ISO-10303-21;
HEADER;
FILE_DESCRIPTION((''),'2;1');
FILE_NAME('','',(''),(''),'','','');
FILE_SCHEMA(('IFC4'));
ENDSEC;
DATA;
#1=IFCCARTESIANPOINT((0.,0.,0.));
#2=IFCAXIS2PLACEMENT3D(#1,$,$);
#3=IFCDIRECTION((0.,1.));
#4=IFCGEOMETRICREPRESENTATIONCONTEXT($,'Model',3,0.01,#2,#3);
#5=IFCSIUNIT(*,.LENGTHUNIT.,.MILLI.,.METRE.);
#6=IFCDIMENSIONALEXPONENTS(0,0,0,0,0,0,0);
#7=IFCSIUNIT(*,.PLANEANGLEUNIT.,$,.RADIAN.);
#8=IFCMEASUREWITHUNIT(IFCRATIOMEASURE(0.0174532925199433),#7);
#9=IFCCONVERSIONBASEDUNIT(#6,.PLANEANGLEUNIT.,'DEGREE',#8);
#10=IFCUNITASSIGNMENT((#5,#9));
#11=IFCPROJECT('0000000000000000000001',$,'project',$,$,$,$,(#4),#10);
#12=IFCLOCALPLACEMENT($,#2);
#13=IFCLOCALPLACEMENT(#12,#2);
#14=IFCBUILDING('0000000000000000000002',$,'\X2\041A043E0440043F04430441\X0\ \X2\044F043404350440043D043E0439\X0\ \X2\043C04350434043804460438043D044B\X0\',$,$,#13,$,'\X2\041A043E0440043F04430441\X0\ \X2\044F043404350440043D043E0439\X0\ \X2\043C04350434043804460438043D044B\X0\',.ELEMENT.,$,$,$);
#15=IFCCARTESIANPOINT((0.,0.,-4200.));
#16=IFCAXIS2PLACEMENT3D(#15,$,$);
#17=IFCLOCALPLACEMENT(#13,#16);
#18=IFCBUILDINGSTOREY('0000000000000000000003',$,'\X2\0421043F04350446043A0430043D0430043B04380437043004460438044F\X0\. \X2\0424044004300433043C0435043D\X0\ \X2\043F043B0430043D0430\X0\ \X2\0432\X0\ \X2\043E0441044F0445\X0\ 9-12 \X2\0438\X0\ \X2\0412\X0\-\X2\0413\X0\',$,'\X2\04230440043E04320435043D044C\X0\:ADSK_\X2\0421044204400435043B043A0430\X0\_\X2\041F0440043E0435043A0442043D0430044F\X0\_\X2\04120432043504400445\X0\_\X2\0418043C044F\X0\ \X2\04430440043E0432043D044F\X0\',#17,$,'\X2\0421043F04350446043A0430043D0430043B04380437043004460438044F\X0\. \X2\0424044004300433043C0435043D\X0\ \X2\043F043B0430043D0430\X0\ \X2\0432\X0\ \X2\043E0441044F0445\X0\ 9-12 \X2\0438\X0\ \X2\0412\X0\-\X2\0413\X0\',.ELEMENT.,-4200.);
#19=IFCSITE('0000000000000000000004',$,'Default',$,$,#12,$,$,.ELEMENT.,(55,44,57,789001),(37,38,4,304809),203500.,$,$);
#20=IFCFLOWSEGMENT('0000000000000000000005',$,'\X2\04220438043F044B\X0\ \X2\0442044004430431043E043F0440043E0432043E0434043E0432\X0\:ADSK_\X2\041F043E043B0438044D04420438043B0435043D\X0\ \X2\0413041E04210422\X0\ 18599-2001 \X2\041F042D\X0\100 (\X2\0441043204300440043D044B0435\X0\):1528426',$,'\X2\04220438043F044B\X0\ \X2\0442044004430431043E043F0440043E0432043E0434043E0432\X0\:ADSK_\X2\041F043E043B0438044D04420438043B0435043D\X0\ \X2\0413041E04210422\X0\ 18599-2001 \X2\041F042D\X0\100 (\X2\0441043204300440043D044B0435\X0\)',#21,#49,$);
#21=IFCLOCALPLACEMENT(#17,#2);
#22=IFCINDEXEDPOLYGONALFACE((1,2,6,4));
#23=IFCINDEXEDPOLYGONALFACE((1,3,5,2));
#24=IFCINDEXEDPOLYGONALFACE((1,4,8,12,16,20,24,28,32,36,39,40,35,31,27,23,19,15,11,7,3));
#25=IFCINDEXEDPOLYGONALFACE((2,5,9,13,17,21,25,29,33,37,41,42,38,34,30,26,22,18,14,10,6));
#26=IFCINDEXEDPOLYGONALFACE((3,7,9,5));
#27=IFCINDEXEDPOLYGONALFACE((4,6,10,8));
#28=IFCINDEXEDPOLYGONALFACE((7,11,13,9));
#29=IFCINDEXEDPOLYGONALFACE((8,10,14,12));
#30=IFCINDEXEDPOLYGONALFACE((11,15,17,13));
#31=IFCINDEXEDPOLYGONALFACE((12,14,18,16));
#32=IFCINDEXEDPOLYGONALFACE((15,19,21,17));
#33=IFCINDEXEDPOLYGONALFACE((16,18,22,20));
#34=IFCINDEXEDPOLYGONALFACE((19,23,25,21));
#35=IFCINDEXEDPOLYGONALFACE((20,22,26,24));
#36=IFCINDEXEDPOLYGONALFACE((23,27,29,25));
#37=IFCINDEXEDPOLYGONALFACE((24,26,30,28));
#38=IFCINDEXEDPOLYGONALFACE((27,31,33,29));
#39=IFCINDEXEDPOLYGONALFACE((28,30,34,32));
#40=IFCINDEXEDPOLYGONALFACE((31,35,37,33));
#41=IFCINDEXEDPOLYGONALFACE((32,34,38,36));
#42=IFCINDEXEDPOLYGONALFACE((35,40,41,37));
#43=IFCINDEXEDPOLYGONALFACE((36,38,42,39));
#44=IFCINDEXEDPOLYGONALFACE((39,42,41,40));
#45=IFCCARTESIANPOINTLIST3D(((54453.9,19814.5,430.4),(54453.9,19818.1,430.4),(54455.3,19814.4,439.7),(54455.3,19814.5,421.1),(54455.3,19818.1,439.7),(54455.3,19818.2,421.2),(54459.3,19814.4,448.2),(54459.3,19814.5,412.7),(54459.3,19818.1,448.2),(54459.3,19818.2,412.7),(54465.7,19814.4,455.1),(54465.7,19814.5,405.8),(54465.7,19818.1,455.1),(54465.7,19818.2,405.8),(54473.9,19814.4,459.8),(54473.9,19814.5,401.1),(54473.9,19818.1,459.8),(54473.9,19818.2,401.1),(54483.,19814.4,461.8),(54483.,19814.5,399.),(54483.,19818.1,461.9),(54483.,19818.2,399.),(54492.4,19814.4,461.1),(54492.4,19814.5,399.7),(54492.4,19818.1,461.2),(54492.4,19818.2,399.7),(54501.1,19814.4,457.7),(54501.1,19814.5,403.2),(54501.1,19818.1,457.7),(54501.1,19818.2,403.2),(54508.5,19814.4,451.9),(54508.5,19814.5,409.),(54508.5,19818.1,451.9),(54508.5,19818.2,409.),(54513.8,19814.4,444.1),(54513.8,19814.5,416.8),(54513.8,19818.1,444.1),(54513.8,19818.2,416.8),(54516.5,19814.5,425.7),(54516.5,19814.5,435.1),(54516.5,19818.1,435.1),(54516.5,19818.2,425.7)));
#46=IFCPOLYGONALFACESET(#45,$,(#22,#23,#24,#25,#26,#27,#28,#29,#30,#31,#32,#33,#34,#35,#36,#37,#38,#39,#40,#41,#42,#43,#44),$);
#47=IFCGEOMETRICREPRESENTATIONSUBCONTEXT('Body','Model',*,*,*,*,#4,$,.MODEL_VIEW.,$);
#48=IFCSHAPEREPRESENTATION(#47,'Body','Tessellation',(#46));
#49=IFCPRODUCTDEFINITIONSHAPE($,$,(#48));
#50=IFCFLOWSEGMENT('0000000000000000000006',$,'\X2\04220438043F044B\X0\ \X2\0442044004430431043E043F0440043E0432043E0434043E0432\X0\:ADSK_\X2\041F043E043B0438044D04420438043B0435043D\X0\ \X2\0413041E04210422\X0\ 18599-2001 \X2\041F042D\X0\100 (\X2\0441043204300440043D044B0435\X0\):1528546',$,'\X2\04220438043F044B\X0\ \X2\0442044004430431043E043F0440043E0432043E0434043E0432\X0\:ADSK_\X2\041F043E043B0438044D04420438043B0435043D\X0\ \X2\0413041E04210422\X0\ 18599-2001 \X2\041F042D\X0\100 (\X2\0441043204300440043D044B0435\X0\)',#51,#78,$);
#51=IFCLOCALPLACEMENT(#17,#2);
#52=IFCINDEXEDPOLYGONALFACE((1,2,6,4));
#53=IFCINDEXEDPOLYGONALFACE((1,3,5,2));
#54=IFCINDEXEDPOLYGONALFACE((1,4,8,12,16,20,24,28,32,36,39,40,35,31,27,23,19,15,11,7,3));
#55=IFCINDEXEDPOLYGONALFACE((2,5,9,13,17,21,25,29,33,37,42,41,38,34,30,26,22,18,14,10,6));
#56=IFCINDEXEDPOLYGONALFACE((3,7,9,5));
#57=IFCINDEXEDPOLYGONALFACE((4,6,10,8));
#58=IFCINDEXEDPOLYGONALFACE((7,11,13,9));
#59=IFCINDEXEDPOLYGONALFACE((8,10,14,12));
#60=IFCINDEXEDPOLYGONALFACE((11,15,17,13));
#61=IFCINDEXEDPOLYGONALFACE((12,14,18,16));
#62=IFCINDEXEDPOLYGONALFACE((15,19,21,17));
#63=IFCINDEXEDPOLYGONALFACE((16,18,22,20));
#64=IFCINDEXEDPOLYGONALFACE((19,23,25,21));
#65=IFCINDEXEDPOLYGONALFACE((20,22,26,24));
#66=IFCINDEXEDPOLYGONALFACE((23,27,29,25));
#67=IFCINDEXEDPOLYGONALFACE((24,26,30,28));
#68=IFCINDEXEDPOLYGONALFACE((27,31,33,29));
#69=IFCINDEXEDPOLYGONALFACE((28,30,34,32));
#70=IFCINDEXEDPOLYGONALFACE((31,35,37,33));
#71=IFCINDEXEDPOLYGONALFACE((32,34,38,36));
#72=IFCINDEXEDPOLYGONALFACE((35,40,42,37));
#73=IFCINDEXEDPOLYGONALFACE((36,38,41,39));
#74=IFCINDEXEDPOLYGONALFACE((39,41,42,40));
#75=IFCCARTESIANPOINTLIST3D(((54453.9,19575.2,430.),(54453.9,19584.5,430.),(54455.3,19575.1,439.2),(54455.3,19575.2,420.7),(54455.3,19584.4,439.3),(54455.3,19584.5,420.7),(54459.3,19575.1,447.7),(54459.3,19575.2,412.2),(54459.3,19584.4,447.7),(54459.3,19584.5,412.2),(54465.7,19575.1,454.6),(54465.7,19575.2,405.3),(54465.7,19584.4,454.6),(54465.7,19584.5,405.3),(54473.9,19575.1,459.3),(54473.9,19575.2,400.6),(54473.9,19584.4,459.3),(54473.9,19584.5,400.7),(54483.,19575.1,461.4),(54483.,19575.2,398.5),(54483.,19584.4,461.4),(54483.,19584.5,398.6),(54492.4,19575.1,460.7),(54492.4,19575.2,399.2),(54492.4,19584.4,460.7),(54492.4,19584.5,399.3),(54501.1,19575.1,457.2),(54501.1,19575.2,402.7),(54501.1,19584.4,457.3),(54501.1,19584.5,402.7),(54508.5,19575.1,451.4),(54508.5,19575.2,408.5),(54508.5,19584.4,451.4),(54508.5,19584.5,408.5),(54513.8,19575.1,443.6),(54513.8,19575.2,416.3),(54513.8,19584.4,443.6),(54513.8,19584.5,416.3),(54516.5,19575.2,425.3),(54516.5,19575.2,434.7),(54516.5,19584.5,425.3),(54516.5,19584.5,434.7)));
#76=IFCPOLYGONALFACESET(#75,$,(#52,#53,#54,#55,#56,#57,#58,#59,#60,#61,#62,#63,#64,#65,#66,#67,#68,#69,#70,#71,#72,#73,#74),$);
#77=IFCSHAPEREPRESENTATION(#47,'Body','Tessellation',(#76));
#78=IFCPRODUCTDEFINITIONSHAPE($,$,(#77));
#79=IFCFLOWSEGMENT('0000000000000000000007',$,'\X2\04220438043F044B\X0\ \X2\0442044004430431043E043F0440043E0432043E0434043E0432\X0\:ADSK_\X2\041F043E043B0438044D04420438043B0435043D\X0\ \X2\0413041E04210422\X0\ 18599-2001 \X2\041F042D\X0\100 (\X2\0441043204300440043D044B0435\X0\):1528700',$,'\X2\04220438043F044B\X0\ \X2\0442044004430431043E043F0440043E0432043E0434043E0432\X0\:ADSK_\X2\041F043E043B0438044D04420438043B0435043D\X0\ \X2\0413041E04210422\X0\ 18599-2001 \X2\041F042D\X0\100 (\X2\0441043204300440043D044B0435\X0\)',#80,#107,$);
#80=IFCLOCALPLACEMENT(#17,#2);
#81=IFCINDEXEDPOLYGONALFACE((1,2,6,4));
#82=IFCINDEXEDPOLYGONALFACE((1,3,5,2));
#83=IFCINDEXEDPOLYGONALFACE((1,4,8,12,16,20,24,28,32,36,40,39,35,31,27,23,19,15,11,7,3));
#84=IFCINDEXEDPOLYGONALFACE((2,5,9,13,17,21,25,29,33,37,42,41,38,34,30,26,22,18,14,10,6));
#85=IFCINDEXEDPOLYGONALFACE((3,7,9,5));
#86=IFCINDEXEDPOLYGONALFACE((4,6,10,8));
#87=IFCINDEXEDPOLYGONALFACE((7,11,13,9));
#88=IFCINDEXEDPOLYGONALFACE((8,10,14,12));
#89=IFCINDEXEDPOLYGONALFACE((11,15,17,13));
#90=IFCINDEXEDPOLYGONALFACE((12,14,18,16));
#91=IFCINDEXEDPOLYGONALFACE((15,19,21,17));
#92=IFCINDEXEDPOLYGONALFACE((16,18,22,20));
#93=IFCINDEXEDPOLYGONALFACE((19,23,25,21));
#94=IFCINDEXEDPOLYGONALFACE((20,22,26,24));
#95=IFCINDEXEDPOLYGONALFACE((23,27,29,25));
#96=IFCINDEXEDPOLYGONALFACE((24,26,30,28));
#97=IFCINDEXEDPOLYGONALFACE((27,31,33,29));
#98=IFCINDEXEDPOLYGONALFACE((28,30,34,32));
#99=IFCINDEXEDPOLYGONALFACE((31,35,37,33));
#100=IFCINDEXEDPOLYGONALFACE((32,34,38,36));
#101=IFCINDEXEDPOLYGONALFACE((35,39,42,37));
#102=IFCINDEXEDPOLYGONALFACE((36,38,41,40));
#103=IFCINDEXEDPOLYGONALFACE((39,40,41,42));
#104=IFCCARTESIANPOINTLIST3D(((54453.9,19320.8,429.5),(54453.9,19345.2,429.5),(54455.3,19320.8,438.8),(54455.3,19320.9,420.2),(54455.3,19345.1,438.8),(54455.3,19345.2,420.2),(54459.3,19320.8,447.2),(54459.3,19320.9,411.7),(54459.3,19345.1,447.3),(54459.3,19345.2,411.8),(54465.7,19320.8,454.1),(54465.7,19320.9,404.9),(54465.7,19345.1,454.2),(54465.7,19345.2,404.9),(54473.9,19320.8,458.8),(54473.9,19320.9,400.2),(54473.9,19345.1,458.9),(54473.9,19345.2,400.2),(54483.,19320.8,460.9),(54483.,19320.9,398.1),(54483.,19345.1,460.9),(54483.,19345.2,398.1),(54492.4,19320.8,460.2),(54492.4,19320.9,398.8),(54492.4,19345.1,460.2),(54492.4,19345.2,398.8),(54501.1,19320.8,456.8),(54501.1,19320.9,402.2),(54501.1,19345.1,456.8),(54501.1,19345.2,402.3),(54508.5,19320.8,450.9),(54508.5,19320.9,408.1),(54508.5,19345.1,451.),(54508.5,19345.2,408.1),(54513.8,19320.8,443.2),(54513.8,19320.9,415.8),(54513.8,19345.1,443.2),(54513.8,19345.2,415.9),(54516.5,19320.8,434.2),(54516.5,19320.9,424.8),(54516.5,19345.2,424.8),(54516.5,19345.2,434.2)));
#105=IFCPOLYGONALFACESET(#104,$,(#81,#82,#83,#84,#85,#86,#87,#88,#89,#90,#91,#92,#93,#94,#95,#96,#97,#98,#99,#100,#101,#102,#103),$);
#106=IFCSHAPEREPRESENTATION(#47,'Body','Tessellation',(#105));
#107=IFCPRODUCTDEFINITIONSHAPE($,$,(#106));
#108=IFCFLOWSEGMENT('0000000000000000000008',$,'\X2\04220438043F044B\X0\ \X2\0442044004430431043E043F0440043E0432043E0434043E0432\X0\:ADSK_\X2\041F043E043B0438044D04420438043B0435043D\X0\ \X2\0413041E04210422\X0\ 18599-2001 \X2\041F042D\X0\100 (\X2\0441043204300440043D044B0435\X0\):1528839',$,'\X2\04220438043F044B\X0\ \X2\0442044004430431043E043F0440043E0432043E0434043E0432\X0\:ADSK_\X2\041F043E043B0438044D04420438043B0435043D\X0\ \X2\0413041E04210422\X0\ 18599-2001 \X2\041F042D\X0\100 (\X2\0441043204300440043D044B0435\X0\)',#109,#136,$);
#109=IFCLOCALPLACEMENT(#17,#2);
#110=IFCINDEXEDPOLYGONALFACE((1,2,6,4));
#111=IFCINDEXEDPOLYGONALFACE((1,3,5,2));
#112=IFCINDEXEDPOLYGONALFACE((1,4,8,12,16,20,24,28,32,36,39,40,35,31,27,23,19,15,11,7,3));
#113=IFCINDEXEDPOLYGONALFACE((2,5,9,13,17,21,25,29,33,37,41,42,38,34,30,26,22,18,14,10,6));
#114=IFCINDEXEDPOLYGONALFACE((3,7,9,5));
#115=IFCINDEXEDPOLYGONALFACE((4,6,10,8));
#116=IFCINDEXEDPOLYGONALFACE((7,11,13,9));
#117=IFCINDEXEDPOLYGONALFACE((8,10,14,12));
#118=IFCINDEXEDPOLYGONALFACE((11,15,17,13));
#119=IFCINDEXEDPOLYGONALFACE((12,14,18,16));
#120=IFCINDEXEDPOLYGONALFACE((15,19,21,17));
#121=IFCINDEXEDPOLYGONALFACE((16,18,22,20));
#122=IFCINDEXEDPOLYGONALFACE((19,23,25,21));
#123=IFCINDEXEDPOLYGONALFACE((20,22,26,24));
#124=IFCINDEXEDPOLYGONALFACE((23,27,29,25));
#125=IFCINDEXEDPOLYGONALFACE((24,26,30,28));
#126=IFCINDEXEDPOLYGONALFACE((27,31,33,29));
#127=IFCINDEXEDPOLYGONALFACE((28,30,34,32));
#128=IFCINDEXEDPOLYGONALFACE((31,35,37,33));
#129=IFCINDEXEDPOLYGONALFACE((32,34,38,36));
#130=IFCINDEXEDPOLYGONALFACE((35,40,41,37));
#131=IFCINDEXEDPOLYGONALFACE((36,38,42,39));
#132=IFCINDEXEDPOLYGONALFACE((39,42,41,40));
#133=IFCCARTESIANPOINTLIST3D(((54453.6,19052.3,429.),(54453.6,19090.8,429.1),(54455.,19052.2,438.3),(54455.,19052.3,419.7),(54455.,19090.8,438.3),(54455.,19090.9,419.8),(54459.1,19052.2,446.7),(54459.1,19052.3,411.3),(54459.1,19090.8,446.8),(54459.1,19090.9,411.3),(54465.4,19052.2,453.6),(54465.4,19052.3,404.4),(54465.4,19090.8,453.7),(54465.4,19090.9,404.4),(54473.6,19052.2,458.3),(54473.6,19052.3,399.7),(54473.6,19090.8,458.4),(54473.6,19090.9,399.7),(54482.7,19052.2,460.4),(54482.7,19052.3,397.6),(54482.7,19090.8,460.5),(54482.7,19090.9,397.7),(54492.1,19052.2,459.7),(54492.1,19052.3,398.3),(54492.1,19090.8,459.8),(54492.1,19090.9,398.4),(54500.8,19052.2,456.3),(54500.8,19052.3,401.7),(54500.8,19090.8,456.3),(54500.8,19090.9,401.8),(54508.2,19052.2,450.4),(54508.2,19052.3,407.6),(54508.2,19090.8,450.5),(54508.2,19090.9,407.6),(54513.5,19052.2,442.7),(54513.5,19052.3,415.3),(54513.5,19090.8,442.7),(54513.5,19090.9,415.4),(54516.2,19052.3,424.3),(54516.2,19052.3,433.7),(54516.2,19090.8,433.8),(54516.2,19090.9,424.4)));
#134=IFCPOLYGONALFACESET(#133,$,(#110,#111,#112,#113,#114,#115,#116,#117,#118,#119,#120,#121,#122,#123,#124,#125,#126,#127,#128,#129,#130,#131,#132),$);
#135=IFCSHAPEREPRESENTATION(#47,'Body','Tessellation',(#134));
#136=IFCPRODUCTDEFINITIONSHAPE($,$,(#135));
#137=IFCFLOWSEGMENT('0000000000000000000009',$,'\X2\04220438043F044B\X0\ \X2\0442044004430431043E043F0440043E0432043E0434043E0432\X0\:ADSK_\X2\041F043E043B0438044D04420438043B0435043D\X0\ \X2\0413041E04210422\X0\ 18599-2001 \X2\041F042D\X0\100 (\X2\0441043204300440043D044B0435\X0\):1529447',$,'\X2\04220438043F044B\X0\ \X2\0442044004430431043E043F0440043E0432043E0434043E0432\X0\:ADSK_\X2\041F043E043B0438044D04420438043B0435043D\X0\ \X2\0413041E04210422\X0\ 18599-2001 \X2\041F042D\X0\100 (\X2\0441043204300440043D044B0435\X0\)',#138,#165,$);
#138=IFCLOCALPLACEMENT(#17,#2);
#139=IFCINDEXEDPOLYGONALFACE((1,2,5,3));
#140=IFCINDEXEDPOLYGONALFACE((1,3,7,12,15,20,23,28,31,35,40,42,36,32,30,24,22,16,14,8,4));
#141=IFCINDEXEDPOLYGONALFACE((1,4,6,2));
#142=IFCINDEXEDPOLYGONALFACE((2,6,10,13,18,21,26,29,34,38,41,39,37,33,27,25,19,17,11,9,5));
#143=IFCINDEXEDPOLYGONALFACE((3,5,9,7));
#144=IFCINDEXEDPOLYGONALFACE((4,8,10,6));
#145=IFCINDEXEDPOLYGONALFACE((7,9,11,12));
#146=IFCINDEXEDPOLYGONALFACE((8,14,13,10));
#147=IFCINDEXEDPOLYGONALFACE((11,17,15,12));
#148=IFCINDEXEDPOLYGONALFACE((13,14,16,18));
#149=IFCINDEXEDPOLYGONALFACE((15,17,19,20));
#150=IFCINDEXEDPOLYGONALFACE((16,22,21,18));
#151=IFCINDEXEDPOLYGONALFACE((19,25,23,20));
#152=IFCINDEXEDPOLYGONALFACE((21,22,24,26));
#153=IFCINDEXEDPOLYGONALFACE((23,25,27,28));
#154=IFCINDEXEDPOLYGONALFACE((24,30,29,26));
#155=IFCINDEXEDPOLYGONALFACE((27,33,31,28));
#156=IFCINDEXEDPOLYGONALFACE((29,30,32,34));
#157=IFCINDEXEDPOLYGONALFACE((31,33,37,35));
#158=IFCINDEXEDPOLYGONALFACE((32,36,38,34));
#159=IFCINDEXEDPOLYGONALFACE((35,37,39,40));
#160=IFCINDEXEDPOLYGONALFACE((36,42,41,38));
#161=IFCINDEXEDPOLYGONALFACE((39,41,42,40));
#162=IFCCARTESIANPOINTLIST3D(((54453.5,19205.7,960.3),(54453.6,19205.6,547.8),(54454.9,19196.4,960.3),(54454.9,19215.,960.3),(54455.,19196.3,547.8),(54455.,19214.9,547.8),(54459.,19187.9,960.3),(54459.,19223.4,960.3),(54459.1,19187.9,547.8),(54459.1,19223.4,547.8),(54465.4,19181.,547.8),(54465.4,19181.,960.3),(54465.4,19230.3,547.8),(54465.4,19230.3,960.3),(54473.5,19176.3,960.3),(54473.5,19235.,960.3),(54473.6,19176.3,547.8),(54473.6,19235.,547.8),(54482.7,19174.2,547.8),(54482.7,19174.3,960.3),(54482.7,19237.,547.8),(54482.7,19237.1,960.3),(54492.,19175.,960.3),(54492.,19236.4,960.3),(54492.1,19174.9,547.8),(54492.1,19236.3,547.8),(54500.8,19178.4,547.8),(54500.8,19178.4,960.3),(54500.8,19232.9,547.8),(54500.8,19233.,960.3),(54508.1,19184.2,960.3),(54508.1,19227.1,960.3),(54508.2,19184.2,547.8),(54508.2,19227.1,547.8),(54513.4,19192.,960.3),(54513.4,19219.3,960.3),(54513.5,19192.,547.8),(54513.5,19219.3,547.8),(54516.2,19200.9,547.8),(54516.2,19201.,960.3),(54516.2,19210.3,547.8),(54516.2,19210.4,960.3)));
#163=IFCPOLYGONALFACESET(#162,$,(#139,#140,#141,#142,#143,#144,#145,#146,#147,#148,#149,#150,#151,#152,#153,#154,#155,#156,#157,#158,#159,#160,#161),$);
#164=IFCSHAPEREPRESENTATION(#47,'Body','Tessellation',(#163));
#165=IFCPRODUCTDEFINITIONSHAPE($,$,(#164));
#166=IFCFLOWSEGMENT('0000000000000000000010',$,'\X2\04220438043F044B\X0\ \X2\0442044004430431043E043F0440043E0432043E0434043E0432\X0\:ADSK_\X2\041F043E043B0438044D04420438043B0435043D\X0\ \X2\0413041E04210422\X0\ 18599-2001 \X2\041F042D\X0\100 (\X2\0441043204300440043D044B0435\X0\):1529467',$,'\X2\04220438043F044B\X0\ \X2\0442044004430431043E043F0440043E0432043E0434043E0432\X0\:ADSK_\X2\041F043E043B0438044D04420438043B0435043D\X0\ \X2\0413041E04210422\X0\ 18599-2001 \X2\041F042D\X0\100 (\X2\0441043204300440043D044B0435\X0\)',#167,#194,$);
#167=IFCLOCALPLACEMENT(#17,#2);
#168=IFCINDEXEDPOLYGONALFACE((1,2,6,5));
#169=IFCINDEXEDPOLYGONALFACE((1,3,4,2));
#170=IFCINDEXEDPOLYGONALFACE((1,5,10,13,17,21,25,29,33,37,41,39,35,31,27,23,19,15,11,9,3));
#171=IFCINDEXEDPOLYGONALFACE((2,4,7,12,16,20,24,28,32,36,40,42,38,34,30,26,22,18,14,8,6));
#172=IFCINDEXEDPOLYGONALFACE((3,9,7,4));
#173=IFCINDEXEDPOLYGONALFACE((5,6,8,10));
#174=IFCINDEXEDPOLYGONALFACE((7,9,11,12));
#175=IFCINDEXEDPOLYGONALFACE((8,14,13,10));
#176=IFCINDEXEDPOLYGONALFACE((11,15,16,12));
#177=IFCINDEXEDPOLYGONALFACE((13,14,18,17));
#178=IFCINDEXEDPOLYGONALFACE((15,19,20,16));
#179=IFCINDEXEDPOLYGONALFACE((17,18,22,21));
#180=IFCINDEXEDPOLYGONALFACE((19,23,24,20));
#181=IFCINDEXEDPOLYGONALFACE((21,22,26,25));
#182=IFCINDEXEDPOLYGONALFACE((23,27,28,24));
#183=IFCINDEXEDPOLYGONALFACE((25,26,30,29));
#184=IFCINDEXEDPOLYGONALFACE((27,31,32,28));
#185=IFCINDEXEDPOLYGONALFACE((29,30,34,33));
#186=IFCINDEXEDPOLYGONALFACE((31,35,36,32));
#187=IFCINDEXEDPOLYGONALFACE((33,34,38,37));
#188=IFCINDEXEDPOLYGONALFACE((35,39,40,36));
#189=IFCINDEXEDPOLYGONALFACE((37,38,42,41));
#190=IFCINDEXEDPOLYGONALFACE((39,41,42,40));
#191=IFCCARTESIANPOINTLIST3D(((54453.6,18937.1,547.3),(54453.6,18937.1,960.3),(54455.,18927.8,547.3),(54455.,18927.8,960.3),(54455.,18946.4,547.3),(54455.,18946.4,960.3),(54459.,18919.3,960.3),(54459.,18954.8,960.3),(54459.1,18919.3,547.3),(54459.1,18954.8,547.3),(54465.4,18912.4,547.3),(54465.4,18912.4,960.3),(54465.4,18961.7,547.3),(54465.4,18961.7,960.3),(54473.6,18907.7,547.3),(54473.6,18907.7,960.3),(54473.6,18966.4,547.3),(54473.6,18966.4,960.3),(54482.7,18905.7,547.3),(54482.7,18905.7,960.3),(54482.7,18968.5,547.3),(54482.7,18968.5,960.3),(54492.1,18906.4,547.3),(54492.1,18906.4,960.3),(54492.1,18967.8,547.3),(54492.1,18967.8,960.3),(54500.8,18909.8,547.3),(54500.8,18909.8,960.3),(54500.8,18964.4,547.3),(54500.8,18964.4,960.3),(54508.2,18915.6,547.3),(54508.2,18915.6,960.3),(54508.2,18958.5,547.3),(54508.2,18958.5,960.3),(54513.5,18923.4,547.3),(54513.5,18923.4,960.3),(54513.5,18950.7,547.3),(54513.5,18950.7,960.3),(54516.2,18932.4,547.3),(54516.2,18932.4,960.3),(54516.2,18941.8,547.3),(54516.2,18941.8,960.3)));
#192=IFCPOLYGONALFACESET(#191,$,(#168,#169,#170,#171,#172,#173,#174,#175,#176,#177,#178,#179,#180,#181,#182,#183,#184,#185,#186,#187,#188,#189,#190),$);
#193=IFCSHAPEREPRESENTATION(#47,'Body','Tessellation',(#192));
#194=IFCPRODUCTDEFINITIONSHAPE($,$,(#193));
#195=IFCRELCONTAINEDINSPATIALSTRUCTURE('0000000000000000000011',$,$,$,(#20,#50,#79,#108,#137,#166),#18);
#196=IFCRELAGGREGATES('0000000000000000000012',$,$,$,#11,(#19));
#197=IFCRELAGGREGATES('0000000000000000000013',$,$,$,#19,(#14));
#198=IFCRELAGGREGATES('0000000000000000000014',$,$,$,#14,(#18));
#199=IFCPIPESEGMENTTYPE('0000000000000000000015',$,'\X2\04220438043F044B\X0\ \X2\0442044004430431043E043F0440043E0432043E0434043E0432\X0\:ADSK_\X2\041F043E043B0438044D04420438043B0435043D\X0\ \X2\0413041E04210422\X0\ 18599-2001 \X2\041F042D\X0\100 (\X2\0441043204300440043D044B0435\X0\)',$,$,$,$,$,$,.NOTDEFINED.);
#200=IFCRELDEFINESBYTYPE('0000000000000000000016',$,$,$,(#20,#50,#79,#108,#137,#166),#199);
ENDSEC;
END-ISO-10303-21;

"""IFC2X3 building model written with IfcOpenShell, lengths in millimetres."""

from ifc_helpers import new_model, entity, si_unit, converted_unit, direction, frame, frame_2d, origin, origin_2d_with_axis, place, context, subcontext, project, spatial, circle, extrude, type_object, element, save


model = new_model("IFC2X3")

# Units and contexts
model_context = context("Model", 3, precision=0.01, world=origin(), true_north=direction((0.0, 1.0)))
body_context = subcontext(model_context, "Body", "Model", "MODEL_VIEW")
ifc_project = project(units=[si_unit("LENGTHUNIT", "METRE", prefix="MILLI"), converted_unit("PLANEANGLEUNIT", "DEGREE", entity("IfcRatioMeasure", 0.0174532925199433), si_unit("PLANEANGLEUNIT", "RADIAN"), dimensions=[0, 0, 0, 0, 0, 0, 0])], contexts=[model_context])

# Site, building, storey
site_placement = place(None, frame((0.0, 0.0, 0.0)))
site = spatial("IfcSite", under=ifc_project, at=site_placement, Name="Default", CompositionType="ELEMENT", RefLatitude=(55, 44, 57, 789001), RefLongitude=(37, 38, 4, 304809), RefElevation=203500.0)
building_placement = place(site_placement, origin())
building = spatial("IfcBuilding", under=site, at=building_placement, Name="Корпус ядерной медицины", LongName="Корпус ядерной медицины", CompositionType="ELEMENT")
storey_placement = place(building_placement, frame((0.0, 0.0, -4200.0)))
storey = spatial("IfcBuildingStorey", under=building, at=storey_placement, Name="Спецканализация. Фрагмен плана в осях 9-12 и В-Г", ObjectType="Уровень:ADSK_Стрелка_Проектная_Вверх_Имя уровня", LongName="Спецканализация. Фрагмен плана в осях 9-12 и В-Г", CompositionType="ELEMENT", Elevation=-4200.0)

# Flow segments
pipe_segment_type = type_object("IfcPipeSegmentType", Name="Типы трубопроводов:ADSK_Полиэтилен ГОСТ 18599-2001 ПЭ100 (сварные)", PredefinedType="NOTDEFINED")
flow_segment_1_placement = place(storey_placement, frame((54452.3, 19814.4, 397.3)))
element("IfcFlowSegment", 1, at=flow_segment_1_placement, inside=storey, type_object=pipe_segment_type, Name="Типы трубопроводов:ADSK_Полиэтилен ГОСТ 18599-2001 ПЭ100 (сварные):1528426", ObjectType="Типы трубопроводов:ADSK_Полиэтилен ГОСТ 18599-2001 ПЭ100 (сварные)", context=body_context, shape_type="SweptSolid", body=[
    extrude(circle(Radius=31.5, at=origin_2d_with_axis()), frame((33.1, 0.1, 33.1), z_axis=(0.0, 0.999998, 0.002), x_axis=(-1.0, 0.0, 0.0)), (0.0, 0.0, 1.0), 3.7),
])
flow_segment_2_placement = place(storey_placement, frame((54452.3, 19575.1, 396.9)))
element("IfcFlowSegment", 2, at=flow_segment_2_placement, inside=storey, type_object=pipe_segment_type, Name="Типы трубопроводов:ADSK_Полиэтилен ГОСТ 18599-2001 ПЭ100 (сварные):1528546", ObjectType="Типы трубопроводов:ADSK_Полиэтилен ГОСТ 18599-2001 ПЭ100 (сварные)", context=body_context, shape_type="SweptSolid", body=[
    extrude(circle(Radius=31.5, at=origin_2d_with_axis()), frame((33.1, 0.1, 33.1), z_axis=(0.0, 0.999998, 0.001851), x_axis=(-1.0, 0.0, 0.0)), (0.0, 0.0, 1.0), 9.3),
])
flow_segment_3_placement = place(storey_placement, frame((54452.3, 19320.8, 396.4)))
element("IfcFlowSegment", 3, at=flow_segment_3_placement, inside=storey, type_object=pipe_segment_type, Name="Типы трубопроводов:ADSK_Полиэтилен ГОСТ 18599-2001 ПЭ100 (сварные):1528700", ObjectType="Типы трубопроводов:ADSK_Полиэтилен ГОСТ 18599-2001 ПЭ100 (сварные)", context=body_context, shape_type="SweptSolid", body=[
    extrude(circle(Radius=31.5, at=frame_2d((0.0, 0.0), x_axis=(1.0, 0.0))), frame((33.1, 0.1, 33.1), z_axis=(0.0, 0.999998, 0.001801), x_axis=(-1.0, 0.0, 0.0)), (0.0, 0.0, 1.0), 24.3),
])
flow_segment_4_placement = place(storey_placement, frame((54452.0, 19052.2, 395.9)))
element("IfcFlowSegment", 4, at=flow_segment_4_placement, inside=storey, type_object=pipe_segment_type, Name="Типы трубопроводов:ADSK_Полиэтилен ГОСТ 18599-2001 ПЭ100 (сварные):1528839", ObjectType="Типы трубопроводов:ADSK_Полиэтилен ГОСТ 18599-2001 ПЭ100 (сварные)", context=body_context, shape_type="SweptSolid", body=[
    extrude(circle(Radius=31.5, at=origin_2d_with_axis()), frame((33.1, 0.1, 33.1), z_axis=(0.000013, 0.999999, 0.001623), x_axis=(-1.0, 0.000013, 0.0)), (0.0, 0.0, 1.0), 38.6),
])
flow_segment_5_placement = place(storey_placement, frame((54451.9, 19172.5, 547.8)))
element("IfcFlowSegment", 5, at=flow_segment_5_placement, inside=storey, type_object=pipe_segment_type, Name="Типы трубопроводов:ADSK_Полиэтилен ГОСТ 18599-2001 ПЭ100 (сварные):1529447", ObjectType="Типы трубопроводов:ADSK_Полиэтилен ГОСТ 18599-2001 ПЭ100 (сварные)", context=body_context, shape_type="SweptSolid", body=[
    extrude(circle(Radius=31.5, at=frame_2d((0.0, 0.0), x_axis=(1.0, 0.0))), frame((33.2, 33.1, 0.0), z_axis=(-0.000137, 0.000088, 1.0), x_axis=(-1.0, 0.0, -0.000137)), (0.0, 0.0, 1.0), 412.5),
])
flow_segment_6_placement = place(storey_placement, frame((54452.0, 18904.0, 547.3)))
element("IfcFlowSegment", 6, at=flow_segment_6_placement, inside=storey, type_object=pipe_segment_type, Name="Типы трубопроводов:ADSK_Полиэтилен ГОСТ 18599-2001 ПЭ100 (сварные):1529467", ObjectType="Типы трубопроводов:ADSK_Полиэтилен ГОСТ 18599-2001 ПЭ100 (сварные)", context=body_context, shape_type="SweptSolid", body=[
    extrude(circle(Radius=31.5, at=origin_2d_with_axis()), frame((33.1, 33.1, 0.0), z_axis=(-0.000001, 0.0, 1.0), x_axis=(-1.0, 0.0, -0.000001)), (0.0, 0.0, 1.0), 413.0),
])

save(model, "model.ifc")
